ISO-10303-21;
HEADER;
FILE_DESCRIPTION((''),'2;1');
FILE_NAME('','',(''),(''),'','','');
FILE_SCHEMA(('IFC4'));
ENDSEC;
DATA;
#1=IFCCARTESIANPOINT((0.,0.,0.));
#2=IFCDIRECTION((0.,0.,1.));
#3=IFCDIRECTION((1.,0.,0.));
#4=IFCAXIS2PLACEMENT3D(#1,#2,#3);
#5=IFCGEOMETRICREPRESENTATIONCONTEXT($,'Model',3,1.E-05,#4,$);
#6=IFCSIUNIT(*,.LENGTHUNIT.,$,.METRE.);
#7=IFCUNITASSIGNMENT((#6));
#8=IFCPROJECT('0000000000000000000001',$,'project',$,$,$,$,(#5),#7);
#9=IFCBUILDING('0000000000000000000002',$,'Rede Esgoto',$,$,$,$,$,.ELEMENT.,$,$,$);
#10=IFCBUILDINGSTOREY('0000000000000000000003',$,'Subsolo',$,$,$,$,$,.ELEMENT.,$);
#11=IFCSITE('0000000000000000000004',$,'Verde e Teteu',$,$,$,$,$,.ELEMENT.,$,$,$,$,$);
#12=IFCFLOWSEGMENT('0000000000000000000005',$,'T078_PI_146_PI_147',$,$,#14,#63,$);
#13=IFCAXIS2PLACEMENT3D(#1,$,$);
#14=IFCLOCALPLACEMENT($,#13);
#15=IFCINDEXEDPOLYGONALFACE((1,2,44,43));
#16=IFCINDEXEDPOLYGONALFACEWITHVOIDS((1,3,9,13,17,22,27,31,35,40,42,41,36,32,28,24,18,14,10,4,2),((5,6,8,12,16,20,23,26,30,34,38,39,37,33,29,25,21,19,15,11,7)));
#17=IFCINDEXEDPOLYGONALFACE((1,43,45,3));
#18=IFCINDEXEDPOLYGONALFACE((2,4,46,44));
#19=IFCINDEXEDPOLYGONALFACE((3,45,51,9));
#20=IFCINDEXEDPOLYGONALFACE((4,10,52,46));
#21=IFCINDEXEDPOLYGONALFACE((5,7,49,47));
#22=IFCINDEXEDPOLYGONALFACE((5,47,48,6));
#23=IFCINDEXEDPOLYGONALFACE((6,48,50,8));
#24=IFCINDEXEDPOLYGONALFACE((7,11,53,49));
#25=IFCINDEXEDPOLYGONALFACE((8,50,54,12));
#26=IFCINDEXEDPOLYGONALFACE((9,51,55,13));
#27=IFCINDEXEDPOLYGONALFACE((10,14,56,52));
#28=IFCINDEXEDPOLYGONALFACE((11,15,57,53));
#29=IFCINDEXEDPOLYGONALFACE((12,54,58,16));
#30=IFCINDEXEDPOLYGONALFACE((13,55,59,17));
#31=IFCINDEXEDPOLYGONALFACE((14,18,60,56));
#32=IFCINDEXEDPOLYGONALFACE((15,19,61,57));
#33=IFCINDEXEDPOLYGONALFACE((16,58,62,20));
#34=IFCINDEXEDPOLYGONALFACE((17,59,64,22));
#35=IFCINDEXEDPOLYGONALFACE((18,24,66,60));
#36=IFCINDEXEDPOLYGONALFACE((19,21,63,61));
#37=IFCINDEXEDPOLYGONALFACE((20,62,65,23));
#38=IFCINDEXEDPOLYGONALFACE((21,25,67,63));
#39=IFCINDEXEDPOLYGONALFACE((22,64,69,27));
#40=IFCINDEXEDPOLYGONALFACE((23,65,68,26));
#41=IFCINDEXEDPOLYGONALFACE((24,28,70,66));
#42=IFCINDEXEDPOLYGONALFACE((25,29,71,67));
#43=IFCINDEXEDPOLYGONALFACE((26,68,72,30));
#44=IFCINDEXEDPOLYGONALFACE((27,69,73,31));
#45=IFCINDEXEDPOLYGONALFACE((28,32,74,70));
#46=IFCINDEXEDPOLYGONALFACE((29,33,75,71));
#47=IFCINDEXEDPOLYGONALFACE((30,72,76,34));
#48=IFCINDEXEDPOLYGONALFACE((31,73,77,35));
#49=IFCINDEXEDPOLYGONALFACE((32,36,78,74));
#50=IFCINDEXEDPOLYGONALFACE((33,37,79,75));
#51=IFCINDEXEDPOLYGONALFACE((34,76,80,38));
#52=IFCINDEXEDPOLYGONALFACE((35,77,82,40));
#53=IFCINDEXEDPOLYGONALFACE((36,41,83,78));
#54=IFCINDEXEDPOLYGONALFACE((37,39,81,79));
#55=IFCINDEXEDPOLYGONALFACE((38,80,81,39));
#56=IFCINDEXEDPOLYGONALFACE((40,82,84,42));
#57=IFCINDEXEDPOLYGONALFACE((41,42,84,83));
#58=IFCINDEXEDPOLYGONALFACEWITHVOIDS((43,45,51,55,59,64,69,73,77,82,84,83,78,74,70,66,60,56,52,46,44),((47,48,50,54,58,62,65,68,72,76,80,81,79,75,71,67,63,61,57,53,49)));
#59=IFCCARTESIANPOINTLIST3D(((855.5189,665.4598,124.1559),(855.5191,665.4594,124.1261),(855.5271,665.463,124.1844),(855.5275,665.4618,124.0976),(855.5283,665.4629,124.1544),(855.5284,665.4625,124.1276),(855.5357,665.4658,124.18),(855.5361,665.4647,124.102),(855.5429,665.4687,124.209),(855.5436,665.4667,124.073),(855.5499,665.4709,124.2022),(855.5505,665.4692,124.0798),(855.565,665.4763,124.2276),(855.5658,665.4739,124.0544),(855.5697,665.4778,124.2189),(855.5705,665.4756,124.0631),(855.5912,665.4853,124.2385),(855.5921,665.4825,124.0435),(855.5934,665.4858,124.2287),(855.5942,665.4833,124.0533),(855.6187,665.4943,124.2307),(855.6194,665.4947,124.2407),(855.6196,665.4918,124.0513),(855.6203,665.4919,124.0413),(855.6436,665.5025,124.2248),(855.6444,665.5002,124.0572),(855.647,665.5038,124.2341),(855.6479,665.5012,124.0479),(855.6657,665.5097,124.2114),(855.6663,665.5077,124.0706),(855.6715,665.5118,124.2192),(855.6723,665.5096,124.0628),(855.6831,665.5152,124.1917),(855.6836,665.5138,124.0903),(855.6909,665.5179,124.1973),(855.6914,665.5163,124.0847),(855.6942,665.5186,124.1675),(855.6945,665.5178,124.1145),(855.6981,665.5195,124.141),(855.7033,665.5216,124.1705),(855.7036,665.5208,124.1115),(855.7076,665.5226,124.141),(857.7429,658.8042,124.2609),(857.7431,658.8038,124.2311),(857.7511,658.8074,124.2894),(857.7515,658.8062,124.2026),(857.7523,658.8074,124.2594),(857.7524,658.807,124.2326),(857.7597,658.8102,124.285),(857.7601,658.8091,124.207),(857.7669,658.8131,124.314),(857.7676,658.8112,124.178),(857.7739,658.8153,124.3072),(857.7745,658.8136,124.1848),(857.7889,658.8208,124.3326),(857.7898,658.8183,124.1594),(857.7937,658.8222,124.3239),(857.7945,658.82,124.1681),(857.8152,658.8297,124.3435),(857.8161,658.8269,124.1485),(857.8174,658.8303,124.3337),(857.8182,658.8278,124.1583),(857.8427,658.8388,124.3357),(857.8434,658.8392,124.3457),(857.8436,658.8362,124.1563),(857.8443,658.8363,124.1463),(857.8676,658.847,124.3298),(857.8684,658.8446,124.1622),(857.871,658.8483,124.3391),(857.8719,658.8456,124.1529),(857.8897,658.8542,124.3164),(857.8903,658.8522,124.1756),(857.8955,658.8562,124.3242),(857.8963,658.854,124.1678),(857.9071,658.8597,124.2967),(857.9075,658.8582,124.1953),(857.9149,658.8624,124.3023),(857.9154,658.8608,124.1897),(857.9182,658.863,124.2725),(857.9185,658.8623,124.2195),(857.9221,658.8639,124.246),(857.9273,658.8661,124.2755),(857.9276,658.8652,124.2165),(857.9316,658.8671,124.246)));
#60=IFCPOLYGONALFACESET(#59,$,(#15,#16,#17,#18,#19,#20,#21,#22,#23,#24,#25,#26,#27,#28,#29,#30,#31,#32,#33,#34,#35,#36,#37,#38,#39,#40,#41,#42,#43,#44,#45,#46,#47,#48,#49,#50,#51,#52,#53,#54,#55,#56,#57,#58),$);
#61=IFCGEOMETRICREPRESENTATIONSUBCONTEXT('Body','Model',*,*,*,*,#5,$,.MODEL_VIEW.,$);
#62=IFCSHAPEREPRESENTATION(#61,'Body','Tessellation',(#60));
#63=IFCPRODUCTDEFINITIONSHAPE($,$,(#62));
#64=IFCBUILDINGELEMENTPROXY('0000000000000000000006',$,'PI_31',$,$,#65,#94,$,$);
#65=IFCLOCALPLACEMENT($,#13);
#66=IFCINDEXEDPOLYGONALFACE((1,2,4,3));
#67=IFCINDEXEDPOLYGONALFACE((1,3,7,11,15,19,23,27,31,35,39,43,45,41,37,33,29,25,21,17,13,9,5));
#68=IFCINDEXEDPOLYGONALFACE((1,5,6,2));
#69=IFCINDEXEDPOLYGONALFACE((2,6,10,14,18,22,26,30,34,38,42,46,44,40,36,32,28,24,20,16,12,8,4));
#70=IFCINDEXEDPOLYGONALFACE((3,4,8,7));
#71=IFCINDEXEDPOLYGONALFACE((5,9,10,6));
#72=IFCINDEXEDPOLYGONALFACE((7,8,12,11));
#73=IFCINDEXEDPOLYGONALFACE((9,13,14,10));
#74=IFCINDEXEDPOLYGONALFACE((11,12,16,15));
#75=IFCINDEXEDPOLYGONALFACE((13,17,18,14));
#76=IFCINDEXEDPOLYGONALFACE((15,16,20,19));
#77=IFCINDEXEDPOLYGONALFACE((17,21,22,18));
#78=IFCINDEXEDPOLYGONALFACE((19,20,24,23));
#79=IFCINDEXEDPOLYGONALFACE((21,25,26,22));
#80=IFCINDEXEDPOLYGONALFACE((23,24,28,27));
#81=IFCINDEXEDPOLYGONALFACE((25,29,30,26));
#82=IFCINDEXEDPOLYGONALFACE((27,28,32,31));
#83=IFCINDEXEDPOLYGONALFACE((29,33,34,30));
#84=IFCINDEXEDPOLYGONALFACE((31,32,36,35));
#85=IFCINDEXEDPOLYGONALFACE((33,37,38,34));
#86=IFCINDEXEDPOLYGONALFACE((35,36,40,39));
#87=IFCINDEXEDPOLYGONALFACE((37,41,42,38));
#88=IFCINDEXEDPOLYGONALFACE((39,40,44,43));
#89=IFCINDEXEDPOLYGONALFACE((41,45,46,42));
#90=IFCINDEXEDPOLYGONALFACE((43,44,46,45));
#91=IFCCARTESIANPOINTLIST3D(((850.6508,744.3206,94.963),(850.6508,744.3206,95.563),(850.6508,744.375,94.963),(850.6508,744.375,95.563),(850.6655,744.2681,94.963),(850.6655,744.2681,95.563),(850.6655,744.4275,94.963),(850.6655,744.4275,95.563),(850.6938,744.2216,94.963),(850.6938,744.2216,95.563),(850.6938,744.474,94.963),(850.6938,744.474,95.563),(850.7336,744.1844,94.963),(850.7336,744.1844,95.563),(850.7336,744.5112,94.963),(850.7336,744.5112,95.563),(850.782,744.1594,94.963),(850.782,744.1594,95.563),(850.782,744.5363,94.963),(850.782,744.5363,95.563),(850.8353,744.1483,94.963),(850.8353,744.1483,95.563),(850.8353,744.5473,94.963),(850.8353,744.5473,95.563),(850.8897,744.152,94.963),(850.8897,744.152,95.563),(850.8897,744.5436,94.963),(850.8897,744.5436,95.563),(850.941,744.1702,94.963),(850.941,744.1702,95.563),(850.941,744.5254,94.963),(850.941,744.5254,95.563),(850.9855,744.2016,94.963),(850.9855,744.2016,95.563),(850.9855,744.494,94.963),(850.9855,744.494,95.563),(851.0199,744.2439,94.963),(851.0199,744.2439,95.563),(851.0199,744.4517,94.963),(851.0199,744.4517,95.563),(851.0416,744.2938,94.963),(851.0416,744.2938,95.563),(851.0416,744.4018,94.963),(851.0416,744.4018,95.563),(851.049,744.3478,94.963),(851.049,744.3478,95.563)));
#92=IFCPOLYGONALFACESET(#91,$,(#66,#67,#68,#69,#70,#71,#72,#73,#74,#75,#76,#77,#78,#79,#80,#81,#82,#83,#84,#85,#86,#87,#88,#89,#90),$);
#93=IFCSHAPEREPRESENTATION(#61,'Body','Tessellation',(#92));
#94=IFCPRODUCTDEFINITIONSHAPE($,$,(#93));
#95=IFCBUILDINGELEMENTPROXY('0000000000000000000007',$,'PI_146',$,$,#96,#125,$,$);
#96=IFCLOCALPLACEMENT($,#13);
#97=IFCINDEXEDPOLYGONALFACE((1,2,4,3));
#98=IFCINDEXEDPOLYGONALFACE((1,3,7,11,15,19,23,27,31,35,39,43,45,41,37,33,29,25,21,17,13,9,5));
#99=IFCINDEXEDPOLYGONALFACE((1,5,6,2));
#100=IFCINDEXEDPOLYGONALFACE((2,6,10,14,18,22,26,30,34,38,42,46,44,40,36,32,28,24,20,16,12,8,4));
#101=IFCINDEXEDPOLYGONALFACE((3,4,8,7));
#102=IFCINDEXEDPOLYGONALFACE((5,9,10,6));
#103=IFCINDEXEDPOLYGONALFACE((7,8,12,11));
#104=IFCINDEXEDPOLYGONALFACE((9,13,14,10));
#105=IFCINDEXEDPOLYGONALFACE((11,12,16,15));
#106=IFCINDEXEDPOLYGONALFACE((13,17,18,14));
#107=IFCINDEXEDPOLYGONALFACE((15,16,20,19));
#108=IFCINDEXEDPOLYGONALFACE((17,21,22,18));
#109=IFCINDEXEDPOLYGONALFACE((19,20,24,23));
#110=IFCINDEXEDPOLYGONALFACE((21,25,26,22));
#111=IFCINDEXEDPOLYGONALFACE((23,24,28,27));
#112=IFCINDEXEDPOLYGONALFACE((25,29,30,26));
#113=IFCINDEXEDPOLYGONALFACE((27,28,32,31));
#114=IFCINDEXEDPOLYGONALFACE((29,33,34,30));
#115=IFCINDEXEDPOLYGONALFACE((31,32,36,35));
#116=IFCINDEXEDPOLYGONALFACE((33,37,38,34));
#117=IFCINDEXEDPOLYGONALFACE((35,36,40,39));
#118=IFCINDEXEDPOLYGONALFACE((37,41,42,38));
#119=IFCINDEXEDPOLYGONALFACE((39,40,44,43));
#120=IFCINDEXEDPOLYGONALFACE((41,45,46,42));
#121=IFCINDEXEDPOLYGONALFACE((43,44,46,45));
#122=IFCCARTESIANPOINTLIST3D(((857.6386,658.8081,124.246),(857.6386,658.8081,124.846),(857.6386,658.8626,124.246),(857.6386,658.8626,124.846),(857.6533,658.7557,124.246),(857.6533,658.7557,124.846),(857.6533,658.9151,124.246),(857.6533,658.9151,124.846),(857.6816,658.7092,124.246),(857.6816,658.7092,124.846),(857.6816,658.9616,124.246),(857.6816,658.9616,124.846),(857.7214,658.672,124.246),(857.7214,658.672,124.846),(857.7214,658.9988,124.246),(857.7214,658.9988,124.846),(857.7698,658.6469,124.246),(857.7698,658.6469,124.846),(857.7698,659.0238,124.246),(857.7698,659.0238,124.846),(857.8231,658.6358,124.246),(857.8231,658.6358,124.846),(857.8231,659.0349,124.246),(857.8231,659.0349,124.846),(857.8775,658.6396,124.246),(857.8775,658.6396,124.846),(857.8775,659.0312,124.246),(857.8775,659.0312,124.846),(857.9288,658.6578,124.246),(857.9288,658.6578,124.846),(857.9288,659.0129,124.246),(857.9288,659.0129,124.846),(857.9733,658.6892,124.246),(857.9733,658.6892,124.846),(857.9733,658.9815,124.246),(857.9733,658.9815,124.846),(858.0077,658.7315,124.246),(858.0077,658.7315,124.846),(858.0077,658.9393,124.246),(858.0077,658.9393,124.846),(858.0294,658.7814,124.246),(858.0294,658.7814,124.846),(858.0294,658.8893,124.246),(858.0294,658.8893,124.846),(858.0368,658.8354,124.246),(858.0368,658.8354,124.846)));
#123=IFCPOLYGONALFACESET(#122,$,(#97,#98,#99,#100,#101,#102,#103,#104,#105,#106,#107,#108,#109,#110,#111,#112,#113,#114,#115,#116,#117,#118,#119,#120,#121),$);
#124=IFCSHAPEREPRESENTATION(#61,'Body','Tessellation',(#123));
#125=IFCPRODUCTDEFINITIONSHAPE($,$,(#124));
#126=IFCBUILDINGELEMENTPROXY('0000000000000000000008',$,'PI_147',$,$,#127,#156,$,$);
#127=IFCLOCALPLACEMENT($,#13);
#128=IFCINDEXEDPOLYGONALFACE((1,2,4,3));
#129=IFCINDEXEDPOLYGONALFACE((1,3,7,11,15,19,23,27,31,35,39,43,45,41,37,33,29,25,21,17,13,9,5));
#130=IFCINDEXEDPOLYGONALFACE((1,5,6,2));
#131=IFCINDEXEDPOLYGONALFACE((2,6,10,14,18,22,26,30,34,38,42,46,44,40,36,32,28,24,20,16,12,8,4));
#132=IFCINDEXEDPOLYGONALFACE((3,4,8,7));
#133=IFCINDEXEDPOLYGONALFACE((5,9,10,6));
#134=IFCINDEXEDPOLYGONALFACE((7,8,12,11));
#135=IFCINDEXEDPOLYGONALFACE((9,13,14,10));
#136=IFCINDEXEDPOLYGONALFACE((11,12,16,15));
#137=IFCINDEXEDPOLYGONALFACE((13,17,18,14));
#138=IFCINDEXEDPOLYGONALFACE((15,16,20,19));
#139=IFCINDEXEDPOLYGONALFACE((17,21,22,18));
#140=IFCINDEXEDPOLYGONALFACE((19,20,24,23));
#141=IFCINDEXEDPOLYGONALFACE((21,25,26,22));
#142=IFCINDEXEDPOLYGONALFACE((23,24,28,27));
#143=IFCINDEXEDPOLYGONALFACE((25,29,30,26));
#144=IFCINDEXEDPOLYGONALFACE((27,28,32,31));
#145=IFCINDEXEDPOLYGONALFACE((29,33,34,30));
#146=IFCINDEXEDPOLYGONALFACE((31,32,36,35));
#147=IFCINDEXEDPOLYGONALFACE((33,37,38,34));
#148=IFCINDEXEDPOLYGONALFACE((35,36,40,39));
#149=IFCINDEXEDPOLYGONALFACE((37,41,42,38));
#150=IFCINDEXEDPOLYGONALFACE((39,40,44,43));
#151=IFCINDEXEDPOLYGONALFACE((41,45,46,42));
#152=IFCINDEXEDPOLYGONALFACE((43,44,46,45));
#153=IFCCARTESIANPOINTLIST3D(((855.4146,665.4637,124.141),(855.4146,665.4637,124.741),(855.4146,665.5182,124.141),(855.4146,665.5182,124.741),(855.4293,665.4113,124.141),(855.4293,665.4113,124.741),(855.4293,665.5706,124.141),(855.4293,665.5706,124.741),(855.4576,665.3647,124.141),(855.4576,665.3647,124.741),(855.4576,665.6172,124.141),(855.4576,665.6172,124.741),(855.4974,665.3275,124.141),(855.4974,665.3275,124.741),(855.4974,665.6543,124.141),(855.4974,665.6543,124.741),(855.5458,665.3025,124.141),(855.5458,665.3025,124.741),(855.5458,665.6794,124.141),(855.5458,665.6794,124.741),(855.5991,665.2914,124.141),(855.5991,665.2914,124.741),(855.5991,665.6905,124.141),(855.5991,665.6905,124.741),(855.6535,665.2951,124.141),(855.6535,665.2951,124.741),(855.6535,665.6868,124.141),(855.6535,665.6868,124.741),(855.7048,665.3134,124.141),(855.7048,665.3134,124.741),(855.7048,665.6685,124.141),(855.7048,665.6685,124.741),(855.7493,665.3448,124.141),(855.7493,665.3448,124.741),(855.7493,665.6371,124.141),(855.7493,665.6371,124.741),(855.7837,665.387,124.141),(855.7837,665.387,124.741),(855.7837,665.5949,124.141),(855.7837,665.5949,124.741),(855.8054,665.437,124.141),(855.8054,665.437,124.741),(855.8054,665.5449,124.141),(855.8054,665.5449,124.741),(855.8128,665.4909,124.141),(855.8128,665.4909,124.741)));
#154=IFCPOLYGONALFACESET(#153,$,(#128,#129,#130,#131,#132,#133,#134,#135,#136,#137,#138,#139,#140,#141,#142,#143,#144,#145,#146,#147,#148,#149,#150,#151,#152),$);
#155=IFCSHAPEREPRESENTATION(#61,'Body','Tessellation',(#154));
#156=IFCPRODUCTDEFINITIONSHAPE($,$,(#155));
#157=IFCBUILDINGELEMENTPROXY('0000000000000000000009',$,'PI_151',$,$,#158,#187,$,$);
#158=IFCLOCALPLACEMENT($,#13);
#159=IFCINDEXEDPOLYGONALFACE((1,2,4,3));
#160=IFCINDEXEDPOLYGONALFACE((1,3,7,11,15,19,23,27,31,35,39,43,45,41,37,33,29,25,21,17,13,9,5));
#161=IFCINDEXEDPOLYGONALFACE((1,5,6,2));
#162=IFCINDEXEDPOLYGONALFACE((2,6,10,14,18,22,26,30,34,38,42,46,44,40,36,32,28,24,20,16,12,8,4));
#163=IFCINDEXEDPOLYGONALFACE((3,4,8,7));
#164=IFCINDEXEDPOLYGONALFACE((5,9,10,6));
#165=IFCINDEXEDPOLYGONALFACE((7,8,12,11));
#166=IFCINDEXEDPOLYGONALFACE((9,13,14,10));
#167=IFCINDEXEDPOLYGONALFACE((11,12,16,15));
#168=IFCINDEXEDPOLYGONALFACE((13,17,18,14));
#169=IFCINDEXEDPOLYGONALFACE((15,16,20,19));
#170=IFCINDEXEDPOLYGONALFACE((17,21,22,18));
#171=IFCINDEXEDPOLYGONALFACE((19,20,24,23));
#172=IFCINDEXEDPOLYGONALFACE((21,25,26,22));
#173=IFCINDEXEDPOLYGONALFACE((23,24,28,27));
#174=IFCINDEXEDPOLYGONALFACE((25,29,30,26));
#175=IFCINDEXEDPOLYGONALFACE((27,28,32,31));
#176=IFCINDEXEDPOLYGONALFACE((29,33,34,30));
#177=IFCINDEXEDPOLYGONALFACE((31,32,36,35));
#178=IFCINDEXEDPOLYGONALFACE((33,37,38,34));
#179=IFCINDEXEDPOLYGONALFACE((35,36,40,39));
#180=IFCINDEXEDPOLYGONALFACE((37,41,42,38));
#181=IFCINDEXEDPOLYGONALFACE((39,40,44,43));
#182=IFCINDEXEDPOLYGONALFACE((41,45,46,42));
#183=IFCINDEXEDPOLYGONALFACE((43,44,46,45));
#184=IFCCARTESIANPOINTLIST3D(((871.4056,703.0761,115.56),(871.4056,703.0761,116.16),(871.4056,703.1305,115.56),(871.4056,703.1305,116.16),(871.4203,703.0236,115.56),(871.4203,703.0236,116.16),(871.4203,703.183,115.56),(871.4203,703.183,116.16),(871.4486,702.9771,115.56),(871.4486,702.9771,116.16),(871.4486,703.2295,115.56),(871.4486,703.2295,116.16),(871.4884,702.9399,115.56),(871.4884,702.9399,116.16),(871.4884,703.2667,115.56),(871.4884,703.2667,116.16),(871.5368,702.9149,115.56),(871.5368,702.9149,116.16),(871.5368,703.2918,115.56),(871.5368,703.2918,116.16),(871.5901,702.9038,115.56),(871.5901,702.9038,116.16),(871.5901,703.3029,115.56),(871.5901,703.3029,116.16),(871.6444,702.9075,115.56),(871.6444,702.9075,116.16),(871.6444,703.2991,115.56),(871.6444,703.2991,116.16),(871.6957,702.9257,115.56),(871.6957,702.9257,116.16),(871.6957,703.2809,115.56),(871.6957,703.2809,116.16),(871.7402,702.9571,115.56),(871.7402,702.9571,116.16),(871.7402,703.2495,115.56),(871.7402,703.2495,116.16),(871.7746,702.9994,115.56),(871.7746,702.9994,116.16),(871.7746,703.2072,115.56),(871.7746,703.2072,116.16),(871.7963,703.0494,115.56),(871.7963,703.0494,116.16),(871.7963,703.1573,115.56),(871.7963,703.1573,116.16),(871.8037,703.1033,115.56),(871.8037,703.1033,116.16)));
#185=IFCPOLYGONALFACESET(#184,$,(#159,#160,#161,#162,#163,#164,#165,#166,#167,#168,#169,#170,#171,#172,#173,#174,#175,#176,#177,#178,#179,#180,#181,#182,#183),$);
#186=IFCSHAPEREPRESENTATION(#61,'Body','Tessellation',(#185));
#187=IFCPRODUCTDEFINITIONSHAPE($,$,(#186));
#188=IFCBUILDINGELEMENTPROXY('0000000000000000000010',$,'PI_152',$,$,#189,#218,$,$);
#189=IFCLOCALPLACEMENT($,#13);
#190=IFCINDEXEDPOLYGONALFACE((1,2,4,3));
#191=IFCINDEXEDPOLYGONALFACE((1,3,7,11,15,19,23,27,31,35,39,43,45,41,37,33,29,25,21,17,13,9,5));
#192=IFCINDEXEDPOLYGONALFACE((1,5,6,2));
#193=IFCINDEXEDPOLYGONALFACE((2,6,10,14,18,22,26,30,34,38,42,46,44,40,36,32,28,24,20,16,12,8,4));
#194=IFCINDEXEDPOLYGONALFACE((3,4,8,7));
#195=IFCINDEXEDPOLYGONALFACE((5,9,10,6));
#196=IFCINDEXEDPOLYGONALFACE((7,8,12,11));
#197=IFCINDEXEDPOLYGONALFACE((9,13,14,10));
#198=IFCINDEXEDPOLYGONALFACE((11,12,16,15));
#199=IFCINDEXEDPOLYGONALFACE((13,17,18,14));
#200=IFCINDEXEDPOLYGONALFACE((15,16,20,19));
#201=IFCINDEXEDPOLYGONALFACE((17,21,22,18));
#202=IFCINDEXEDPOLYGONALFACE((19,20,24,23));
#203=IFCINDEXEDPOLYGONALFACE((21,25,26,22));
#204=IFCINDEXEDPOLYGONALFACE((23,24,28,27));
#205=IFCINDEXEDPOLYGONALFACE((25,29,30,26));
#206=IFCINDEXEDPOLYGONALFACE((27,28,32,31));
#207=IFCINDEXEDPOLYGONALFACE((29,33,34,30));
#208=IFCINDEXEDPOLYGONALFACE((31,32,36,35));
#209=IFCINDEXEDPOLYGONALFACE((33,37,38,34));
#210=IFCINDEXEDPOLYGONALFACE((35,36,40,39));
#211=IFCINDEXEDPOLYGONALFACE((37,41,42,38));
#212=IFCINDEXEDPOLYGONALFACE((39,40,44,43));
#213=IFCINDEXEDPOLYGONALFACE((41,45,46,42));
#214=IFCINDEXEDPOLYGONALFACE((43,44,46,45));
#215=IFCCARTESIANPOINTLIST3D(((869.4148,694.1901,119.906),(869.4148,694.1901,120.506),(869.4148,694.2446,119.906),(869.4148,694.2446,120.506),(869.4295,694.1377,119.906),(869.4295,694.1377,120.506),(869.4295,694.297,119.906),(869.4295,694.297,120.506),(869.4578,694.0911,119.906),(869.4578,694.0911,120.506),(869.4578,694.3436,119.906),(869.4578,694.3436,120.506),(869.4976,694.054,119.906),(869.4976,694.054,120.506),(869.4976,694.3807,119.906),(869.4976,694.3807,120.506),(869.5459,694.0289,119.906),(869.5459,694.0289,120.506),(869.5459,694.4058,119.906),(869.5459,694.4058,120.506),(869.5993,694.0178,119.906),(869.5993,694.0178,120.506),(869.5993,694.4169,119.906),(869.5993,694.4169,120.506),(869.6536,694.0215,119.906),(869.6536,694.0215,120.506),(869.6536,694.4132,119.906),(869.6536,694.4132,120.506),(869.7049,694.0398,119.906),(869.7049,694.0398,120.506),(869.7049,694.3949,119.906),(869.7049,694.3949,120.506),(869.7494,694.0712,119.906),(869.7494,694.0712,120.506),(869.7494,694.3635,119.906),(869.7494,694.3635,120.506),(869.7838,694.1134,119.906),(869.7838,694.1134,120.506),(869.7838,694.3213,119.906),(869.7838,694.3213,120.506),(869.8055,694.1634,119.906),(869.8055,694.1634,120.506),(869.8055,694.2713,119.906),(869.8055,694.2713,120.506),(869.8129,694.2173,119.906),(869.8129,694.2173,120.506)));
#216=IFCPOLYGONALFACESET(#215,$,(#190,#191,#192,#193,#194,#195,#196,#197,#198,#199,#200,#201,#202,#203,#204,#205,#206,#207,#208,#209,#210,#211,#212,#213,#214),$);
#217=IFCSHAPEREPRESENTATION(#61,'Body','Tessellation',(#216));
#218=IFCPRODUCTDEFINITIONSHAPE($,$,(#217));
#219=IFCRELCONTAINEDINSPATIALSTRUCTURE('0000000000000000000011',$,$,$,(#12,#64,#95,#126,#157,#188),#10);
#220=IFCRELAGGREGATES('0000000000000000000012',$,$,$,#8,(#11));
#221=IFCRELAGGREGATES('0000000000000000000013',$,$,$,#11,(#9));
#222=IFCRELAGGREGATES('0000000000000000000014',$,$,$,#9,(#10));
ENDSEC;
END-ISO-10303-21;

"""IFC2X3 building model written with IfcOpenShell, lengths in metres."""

from ifc_helpers import new_model, entity, si_unit, frame, origin_with_axes, origin_2d, place, context, subcontext, project, spatial, circle, extrude, element, save


model = new_model("IFC2X3")

# Units and contexts
model_context = context("Model", 3, precision=1e-05, world=origin_with_axes())
body_context = subcontext(model_context, "Body", "Model", "MODEL_VIEW")
ifc_project = project(units=[si_unit("LENGTHUNIT", "METRE")], contexts=[model_context])

# Site, building, storey
site = spatial("IfcSite", under=ifc_project, Name="Verde e Teteu", CompositionType="ELEMENT")
building = spatial("IfcBuilding", under=site, Name="Rede Esgoto", CompositionType="ELEMENT")
storey = spatial("IfcBuildingStorey", under=building, Name="Subsolo", CompositionType="ELEMENT")

# Flow segment
flow_segment_1_placement = place(None, frame((857.8368, 658.8354, 124.246), z_axis=(0.0, 0.0, 1.0), x_axis=(1.0, 0.0, 0.0)))
element("IfcFlowSegment", 1, at=flow_segment_1_placement, inside=storey, Name="T078_PI_146_PI_147", context=body_context, shape_type="SweptSolid", body=[
    entity("IfcSweptDiskSolid", entity("IfcPolyline", [entity("IfcCartesianPoint", [0.0, 0.0, 0.0]), entity("IfcCartesianPoint", [-2.224, 6.6556, -0.105])]), 0.1, 0.09),
])

# Building element proxies
for number, where, z_axis, x_axis, name in (
    (2, (850.849, 744.3478, 94.963), (0.0, 0.0, 1.0), (1.0, 0.0, 0.0), "PI_31"),
    (3, (857.8368, 658.8354, 124.246), (0.0, 0.0, 1.0), (1.0, 0.0, 0.0), "PI_146"),
):
    element("IfcBuildingElementProxy", number, at=place(None, frame(where, z_axis=z_axis, x_axis=x_axis)), inside=storey, Name=name, context=body_context, shape_type="SweptSolid", body=[
        extrude(circle(Radius=0.2, at=origin_2d()), origin_with_axes(), (0.0, 0.0, 1.0), 0.6),
    ])
for number, where, z_axis, x_axis, name in (
    (4, (855.6128, 665.4909, 124.141), (0.0, 0.0, 1.0), (1.0, 0.0, 0.0), "PI_147"),
    (5, (871.6037, 703.1033, 115.56), (0.0, 0.0, 1.0), (1.0, 0.0, 0.0), "PI_151"),
    (6, (869.6129, 694.2173, 119.906), (0.0, 0.0, 1.0), (1.0, 0.0, 0.0), "PI_152"),
):
    element("IfcBuildingElementProxy", number, at=place(None, frame(where, z_axis=z_axis, x_axis=x_axis)), inside=storey, Name=name, context=body_context, shape_type="SweptSolid", body=[
        extrude(circle(Radius=0.2, at=origin_2d()), origin_with_axes(), (0.0, 0.0, 1.0), 0.6),
    ])

save(model, "model.ifc")
